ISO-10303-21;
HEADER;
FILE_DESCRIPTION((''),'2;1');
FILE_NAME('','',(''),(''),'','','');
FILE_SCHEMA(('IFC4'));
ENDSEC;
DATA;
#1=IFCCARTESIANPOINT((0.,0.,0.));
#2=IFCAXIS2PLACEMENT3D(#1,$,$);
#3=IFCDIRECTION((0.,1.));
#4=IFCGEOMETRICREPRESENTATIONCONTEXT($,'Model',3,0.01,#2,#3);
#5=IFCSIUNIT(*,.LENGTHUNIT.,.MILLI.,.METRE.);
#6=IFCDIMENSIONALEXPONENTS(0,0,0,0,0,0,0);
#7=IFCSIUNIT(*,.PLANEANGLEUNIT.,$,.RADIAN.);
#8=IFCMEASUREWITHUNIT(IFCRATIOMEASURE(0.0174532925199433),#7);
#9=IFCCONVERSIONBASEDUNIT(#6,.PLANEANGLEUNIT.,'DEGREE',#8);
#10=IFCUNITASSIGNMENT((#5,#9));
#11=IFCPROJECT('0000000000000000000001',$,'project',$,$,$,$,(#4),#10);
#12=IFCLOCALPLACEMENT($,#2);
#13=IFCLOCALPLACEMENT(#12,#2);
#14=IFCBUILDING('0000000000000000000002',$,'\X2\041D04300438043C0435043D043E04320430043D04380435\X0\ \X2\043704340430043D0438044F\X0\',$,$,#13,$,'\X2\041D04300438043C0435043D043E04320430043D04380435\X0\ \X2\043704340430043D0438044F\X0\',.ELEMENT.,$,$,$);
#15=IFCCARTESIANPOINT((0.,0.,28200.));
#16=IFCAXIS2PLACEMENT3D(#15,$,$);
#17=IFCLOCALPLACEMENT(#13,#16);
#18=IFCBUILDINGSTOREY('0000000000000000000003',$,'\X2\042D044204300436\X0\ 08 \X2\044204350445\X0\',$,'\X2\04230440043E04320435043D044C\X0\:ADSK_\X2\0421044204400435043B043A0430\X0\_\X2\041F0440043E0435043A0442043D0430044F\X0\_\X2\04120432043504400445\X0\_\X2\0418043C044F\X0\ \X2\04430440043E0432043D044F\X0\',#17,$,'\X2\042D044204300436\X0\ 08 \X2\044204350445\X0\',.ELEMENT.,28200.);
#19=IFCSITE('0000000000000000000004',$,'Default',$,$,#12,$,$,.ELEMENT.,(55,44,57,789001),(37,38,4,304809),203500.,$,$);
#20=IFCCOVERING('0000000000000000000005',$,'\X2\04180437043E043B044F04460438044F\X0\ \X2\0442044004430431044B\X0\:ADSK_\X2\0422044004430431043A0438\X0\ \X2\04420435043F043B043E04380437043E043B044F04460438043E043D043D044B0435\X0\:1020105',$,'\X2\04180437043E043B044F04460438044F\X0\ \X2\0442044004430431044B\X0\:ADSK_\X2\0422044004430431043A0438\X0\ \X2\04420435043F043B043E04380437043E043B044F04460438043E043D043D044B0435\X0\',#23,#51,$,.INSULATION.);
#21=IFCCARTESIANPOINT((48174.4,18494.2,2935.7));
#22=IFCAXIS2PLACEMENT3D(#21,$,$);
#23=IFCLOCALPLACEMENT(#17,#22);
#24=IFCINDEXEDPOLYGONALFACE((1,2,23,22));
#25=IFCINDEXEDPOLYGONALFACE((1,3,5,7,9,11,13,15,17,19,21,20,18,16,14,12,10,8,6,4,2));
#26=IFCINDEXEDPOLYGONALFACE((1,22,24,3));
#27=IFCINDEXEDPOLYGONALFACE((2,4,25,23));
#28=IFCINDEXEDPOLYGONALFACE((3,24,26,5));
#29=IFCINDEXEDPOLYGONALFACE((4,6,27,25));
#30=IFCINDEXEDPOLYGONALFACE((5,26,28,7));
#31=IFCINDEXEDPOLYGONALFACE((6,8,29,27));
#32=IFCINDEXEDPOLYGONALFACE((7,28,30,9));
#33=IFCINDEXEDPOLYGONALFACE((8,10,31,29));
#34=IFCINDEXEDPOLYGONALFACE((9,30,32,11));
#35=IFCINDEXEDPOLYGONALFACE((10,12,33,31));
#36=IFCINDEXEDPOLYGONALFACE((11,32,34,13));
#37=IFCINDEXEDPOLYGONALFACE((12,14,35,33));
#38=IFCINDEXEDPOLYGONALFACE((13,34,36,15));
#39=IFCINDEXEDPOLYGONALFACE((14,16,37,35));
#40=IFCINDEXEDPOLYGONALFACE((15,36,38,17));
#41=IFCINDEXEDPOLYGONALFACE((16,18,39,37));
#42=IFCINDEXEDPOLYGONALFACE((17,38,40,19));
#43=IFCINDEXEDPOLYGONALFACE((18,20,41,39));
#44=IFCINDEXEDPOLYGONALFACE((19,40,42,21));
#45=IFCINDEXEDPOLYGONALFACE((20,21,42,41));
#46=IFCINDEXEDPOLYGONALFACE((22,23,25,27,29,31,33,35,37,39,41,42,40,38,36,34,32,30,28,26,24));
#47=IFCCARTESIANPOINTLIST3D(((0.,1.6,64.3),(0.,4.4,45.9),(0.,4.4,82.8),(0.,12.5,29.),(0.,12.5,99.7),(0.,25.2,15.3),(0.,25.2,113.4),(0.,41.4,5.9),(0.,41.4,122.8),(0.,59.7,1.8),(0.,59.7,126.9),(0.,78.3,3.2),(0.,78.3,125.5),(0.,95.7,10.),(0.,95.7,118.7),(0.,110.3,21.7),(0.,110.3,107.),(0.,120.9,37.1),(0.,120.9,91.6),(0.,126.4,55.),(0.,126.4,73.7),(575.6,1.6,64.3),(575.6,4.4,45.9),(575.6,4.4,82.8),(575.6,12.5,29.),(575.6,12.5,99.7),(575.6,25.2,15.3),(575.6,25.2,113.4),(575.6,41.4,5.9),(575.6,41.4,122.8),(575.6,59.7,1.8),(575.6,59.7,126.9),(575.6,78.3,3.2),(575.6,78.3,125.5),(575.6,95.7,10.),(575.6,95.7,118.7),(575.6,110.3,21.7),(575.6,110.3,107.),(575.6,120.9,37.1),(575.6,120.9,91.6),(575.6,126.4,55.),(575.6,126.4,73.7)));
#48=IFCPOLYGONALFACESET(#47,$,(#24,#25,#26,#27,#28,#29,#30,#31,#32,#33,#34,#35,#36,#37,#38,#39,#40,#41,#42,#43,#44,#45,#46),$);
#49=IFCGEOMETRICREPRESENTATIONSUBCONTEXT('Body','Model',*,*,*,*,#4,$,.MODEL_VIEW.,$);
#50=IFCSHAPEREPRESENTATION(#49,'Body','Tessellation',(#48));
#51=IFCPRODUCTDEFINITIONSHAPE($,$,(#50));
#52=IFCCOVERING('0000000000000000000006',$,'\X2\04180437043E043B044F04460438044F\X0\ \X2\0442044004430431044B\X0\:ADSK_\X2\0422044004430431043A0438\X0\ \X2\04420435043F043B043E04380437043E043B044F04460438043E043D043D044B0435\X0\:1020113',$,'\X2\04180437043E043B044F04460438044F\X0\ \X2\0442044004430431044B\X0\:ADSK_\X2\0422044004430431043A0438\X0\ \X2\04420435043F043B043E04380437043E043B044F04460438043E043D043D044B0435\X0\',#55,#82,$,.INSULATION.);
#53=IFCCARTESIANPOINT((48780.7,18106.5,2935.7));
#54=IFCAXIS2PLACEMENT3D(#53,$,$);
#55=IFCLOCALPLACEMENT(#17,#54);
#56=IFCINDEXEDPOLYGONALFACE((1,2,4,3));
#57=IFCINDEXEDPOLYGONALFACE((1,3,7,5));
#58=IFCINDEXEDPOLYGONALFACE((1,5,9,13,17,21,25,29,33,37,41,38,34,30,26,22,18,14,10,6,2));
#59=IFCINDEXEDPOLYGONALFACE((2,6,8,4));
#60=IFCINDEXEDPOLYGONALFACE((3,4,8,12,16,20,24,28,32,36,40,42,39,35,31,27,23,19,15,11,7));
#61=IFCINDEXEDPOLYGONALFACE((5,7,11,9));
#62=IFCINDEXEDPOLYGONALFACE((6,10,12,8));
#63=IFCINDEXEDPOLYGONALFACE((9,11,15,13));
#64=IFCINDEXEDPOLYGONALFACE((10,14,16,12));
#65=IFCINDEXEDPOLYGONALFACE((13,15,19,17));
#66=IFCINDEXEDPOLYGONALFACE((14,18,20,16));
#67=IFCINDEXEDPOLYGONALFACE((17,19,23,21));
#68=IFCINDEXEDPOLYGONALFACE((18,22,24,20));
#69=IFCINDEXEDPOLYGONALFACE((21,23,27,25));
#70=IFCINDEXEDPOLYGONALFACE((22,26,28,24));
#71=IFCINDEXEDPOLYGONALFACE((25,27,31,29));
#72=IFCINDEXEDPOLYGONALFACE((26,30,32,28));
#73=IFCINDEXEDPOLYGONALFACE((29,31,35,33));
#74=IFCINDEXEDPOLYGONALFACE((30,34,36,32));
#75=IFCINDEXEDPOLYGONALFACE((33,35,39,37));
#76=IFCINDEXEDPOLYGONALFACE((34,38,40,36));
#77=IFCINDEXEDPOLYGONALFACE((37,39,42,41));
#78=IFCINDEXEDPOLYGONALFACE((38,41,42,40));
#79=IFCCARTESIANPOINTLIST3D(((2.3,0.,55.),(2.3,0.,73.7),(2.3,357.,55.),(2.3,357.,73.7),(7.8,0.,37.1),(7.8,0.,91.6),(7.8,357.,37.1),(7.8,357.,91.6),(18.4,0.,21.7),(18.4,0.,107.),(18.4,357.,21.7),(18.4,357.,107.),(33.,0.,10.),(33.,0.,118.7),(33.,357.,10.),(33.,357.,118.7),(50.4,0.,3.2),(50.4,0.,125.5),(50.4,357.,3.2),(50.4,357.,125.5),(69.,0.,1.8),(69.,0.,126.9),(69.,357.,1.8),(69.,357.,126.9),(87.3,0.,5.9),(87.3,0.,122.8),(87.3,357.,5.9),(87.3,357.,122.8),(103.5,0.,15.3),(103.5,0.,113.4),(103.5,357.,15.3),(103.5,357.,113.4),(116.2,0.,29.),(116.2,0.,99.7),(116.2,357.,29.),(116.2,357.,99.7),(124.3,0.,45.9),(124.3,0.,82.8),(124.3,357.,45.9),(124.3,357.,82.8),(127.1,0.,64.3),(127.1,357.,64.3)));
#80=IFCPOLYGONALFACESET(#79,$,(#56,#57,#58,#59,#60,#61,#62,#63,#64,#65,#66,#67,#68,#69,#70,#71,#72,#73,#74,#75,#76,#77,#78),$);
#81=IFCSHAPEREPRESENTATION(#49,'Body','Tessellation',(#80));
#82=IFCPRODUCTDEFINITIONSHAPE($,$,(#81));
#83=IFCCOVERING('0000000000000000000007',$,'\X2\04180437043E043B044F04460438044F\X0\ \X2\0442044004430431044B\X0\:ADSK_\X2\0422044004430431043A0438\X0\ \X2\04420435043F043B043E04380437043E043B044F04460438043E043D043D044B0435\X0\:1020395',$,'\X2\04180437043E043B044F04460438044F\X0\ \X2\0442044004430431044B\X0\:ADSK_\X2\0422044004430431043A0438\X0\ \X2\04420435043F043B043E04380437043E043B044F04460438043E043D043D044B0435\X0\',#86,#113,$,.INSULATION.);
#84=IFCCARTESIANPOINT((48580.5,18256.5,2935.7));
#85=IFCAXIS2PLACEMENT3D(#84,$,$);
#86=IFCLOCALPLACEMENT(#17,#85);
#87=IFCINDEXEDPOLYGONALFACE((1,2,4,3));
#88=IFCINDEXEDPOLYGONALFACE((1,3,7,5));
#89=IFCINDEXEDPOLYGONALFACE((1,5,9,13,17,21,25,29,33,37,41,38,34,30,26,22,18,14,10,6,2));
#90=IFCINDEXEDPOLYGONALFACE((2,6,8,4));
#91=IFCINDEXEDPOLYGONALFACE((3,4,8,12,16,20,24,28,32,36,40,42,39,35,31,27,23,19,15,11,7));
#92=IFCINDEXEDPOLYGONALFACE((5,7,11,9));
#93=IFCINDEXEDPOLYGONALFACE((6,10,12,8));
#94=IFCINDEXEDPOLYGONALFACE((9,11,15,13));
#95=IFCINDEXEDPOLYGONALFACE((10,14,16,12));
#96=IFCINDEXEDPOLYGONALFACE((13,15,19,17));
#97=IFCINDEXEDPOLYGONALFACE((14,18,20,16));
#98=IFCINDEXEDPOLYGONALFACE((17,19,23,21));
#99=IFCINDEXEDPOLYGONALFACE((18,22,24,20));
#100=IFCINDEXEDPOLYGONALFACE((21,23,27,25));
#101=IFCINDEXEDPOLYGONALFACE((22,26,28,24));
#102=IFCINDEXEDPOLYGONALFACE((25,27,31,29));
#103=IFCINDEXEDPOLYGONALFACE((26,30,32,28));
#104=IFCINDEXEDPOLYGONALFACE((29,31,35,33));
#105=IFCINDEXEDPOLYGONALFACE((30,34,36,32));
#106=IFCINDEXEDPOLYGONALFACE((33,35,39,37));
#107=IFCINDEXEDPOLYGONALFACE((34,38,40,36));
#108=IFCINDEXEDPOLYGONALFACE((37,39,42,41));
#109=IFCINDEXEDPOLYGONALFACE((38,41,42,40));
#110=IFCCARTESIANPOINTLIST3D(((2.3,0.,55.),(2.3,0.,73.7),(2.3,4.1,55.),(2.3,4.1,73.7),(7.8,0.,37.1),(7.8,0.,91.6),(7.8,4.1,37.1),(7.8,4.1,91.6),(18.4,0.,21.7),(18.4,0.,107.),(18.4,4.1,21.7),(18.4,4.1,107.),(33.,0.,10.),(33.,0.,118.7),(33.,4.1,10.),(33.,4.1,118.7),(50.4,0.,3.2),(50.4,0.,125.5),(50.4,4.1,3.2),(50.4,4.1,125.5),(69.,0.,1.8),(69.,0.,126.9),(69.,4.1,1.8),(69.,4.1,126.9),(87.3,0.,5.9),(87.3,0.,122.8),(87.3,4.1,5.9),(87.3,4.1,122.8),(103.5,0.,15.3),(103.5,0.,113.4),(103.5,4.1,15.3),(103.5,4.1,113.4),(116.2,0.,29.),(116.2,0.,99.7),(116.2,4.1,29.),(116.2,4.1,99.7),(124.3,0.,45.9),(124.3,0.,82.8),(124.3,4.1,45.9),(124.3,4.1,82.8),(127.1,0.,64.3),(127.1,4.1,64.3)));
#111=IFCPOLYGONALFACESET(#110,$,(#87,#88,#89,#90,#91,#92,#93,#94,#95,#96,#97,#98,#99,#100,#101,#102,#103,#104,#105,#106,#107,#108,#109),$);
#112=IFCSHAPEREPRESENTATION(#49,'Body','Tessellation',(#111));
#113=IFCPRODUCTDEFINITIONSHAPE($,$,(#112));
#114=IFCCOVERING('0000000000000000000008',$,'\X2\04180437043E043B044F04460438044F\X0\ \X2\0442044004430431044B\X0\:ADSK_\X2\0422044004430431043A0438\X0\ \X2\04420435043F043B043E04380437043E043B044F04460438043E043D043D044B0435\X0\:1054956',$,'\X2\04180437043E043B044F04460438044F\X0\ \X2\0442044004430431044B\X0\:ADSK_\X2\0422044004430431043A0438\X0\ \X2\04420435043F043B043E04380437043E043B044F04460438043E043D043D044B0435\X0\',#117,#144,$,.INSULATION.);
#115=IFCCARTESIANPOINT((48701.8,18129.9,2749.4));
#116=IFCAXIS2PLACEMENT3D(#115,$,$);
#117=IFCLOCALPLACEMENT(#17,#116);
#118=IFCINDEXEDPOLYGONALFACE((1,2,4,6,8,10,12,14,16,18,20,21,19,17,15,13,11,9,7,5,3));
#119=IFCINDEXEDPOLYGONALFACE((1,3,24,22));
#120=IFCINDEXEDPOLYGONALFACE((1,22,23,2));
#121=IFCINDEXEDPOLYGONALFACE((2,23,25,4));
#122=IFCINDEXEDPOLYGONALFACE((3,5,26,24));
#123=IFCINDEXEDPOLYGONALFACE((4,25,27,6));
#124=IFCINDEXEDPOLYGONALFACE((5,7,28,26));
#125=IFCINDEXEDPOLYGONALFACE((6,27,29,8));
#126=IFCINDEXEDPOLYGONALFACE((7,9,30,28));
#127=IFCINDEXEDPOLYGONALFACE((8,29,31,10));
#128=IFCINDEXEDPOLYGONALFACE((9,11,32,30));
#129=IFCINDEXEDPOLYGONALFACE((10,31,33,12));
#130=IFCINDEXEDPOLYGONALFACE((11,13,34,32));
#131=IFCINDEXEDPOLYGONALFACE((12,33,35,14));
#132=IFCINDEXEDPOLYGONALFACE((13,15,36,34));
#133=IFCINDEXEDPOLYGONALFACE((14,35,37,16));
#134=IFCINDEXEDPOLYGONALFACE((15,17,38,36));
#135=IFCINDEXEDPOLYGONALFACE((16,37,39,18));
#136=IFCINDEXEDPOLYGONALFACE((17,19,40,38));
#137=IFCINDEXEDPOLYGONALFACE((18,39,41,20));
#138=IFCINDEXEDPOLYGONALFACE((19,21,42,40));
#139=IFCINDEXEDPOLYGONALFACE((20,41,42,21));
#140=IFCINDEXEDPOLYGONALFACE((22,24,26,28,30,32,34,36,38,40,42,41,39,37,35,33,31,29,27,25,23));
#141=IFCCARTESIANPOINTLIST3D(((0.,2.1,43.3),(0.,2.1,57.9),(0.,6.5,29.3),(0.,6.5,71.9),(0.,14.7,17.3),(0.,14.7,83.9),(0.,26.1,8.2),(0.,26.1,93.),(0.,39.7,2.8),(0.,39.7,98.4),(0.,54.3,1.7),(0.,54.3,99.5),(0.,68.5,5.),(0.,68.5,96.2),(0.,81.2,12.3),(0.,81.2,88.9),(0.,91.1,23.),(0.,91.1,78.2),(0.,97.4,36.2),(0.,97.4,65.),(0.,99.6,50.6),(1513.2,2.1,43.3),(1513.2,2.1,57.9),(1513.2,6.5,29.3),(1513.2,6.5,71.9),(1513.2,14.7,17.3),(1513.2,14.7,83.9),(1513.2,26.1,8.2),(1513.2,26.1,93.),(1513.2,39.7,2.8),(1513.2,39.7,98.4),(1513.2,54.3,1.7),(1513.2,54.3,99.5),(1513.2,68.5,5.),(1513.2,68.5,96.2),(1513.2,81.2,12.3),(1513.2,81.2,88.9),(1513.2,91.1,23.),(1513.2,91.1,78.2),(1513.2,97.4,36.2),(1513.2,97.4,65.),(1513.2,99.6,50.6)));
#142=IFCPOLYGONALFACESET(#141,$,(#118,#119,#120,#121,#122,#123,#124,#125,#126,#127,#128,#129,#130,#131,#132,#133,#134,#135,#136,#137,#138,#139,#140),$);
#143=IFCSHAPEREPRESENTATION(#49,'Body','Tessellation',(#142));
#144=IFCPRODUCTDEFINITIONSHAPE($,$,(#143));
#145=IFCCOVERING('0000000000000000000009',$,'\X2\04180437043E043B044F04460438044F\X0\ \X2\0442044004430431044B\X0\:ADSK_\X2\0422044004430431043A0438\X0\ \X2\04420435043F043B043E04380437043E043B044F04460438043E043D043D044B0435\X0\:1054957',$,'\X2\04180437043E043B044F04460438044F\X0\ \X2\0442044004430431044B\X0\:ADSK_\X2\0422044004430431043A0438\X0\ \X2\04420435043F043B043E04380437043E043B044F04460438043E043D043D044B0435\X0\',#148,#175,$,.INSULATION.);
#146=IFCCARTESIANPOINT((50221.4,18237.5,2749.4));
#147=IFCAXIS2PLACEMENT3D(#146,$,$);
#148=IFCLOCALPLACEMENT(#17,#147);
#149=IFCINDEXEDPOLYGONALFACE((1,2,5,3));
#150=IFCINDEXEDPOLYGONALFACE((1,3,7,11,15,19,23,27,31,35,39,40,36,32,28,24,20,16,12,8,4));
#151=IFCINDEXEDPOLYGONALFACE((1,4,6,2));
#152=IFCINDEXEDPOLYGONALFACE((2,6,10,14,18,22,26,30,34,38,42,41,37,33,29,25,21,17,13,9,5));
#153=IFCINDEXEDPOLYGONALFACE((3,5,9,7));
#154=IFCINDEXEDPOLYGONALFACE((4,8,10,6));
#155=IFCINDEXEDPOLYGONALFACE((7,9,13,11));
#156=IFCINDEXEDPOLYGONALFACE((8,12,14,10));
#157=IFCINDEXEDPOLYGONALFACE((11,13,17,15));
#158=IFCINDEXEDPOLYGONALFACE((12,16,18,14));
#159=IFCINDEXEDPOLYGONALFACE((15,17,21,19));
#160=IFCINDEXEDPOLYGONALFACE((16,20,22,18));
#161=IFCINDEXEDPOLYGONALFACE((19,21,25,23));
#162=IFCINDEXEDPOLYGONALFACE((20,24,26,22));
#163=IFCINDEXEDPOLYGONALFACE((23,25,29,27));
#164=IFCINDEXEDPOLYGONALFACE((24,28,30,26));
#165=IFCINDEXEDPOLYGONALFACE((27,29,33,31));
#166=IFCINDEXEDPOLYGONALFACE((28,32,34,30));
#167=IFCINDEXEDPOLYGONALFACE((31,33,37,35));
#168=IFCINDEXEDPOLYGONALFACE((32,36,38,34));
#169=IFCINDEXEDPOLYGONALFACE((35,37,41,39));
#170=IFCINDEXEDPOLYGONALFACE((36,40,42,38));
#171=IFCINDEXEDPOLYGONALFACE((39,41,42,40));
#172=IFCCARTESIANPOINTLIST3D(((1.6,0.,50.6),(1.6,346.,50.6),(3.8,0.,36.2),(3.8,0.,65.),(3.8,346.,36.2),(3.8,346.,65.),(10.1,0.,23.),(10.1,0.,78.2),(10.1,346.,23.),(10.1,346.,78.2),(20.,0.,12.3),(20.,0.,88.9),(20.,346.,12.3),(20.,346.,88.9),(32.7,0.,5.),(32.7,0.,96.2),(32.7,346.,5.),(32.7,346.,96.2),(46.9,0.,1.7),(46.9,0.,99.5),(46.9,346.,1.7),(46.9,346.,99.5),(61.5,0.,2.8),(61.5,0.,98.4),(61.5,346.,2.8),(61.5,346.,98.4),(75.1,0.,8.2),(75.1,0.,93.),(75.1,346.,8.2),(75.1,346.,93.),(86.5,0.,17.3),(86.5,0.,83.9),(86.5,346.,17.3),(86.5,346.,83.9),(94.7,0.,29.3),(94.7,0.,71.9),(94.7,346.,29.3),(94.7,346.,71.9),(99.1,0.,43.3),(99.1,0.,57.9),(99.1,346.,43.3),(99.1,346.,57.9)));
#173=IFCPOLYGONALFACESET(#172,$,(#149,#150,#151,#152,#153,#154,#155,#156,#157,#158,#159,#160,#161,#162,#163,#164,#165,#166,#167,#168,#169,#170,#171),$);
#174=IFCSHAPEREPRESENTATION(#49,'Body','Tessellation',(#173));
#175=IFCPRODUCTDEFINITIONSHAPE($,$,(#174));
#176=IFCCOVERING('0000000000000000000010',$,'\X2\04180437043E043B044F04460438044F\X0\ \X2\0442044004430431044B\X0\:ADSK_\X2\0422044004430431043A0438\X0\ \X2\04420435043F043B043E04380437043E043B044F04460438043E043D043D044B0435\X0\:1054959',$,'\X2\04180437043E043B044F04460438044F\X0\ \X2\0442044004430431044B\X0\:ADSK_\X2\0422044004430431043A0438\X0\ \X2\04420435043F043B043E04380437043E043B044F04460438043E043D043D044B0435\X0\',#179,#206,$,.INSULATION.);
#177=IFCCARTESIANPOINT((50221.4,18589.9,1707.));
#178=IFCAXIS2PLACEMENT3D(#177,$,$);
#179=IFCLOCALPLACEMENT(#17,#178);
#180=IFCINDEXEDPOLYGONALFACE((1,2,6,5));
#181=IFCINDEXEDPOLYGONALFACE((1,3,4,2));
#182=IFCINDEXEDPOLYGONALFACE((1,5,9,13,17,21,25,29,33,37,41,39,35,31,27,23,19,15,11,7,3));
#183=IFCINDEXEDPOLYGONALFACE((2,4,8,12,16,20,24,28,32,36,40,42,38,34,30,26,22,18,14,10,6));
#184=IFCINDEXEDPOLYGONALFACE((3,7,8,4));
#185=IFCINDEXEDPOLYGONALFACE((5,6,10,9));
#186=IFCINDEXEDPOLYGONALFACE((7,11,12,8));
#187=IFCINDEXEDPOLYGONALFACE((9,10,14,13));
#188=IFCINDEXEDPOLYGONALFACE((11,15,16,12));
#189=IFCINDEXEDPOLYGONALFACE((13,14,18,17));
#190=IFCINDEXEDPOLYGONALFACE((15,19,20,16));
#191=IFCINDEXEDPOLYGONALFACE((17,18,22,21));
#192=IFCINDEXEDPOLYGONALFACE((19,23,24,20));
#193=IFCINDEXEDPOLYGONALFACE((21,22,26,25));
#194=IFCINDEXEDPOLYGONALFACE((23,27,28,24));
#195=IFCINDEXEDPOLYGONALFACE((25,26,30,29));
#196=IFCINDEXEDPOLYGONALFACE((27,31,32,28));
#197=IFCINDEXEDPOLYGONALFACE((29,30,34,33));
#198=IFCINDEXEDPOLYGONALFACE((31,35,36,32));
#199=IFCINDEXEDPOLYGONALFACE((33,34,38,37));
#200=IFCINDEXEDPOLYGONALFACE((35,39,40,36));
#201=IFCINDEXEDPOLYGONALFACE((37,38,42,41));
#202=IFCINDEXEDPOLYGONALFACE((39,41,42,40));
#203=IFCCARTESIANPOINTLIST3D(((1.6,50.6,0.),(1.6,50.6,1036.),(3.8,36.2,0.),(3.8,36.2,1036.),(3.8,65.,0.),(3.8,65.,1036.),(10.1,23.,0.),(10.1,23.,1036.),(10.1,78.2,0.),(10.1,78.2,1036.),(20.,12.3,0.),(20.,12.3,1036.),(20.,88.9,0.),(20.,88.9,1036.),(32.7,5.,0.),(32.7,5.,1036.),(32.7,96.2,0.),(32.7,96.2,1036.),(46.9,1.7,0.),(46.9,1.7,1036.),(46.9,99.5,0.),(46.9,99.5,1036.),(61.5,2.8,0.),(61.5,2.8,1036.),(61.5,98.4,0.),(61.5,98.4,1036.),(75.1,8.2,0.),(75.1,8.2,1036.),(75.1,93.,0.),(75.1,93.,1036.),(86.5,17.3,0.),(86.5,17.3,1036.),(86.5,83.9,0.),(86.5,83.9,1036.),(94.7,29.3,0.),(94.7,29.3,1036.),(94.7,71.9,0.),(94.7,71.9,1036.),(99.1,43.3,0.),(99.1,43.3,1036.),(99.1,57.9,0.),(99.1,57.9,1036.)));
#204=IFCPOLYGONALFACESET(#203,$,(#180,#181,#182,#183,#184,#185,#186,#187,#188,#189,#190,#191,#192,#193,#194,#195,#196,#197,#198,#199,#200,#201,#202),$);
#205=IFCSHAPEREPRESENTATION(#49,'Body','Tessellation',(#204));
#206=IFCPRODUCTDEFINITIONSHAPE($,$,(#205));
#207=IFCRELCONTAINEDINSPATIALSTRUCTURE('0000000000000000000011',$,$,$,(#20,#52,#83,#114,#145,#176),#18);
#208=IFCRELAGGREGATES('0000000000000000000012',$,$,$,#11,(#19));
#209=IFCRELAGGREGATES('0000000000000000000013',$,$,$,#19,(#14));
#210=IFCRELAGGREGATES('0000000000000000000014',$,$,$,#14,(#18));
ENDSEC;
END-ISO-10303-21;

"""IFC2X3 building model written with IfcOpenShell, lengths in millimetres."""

from ifc_helpers import new_model, entity, si_unit, converted_unit, direction, frame, origin, origin_2d_with_axis, place, context, subcontext, project, spatial, circle, extrude, element, save


model = new_model("IFC2X3")

# Units and contexts
model_context = context("Model", 3, precision=0.01, world=origin(), true_north=direction((0.0, 1.0)))
body_context = subcontext(model_context, "Body", "Model", "MODEL_VIEW")
ifc_project = project(units=[si_unit("LENGTHUNIT", "METRE", prefix="MILLI"), converted_unit("PLANEANGLEUNIT", "DEGREE", entity("IfcRatioMeasure", 0.0174532925199433), si_unit("PLANEANGLEUNIT", "RADIAN"), dimensions=[0, 0, 0, 0, 0, 0, 0])], contexts=[model_context])

# Site, building, storey
site_placement = place(None, origin())
site = spatial("IfcSite", under=ifc_project, at=site_placement, Name="Default", CompositionType="ELEMENT", RefLatitude=(55, 44, 57, 789001), RefLongitude=(37, 38, 4, 304809), RefElevation=203500.0)
building_placement = place(site_placement, origin())
building = spatial("IfcBuilding", under=site, at=building_placement, Name="Наименование здания", LongName="Наименование здания", CompositionType="ELEMENT")
storey_placement = place(building_placement, frame((0.0, 0.0, 28200.0)))
storey = spatial("IfcBuildingStorey", under=building, at=storey_placement, Name="Этаж 08 тех", ObjectType="Уровень:ADSK_Стрелка_Проектная_Вверх_Имя уровня", LongName="Этаж 08 тех", CompositionType="ELEMENT", Elevation=28200.0)

# Coverings
covering_1_placement = place(storey_placement, frame((48174.4, 18494.2, 2935.7)))
element("IfcCovering", 1, at=covering_1_placement, inside=storey, Name="Изоляция трубы:ADSK_Трубки теплоизоляционные:1020105", ObjectType="Изоляция трубы:ADSK_Трубки теплоизоляционные", PredefinedType="INSULATION", context=body_context, shape_type="SweptSolid", body=[
    extrude(circle(Radius=62.8, at=origin_2d_with_axis()), frame((0.0, 64.3, 64.3), z_axis=(1.0, 0.0, 0.0), x_axis=(0.0, -1.0, 0.0)), (0.0, 0.0, 1.0), 575.6),
])
covering_2_placement = place(storey_placement, frame((48780.7, 18106.5, 2935.7)))
element("IfcCovering", 2, at=covering_2_placement, inside=storey, Name="Изоляция трубы:ADSK_Трубки теплоизоляционные:1020113", ObjectType="Изоляция трубы:ADSK_Трубки теплоизоляционные", PredefinedType="INSULATION", context=body_context, shape_type="SweptSolid", body=[
    extrude(circle(Radius=62.8, at=origin_2d_with_axis()), frame((64.3, 0.0, 64.3), z_axis=(0.0, 1.0, 0.0), x_axis=(1.0, 0.0, 0.0)), (0.0, 0.0, 1.0), 357.0),
])
covering_3_placement = place(storey_placement, frame((48580.5, 18256.5, 2935.7)))
element("IfcCovering", 3, at=covering_3_placement, inside=storey, Name="Изоляция трубы:ADSK_Трубки теплоизоляционные:1020395", ObjectType="Изоляция трубы:ADSK_Трубки теплоизоляционные", PredefinedType="INSULATION", context=body_context, shape_type="SweptSolid", body=[
    extrude(circle(Radius=62.8, at=origin_2d_with_axis()), frame((64.3, 0.0, 64.3), z_axis=(0.0, 1.0, 0.0), x_axis=(1.0, 0.0, 0.0)), (0.0, 0.0, 1.0), 4.1),
])
covering_4_placement = place(storey_placement, frame((48701.8, 18129.9, 2749.4)))
element("IfcCovering", 4, at=covering_4_placement, inside=storey, Name="Изоляция трубы:ADSK_Трубки теплоизоляционные:1054956", ObjectType="Изоляция трубы:ADSK_Трубки теплоизоляционные", PredefinedType="INSULATION", context=body_context, shape_type="SweptSolid", body=[
    extrude(circle(Radius=49.0, at=origin_2d_with_axis()), frame((0.0, 50.6, 50.6), z_axis=(1.0, 0.0, 0.0), x_axis=(0.0, 1.0, 0.0)), (0.0, 0.0, 1.0), 1513.2),
])
covering_5_placement = place(storey_placement, frame((50221.4, 18237.5, 2749.4)))
element("IfcCovering", 5, at=covering_5_placement, inside=storey, Name="Изоляция трубы:ADSK_Трубки теплоизоляционные:1054957", ObjectType="Изоляция трубы:ADSK_Трубки теплоизоляционные", PredefinedType="INSULATION", context=body_context, shape_type="SweptSolid", body=[
    extrude(circle(Radius=49.0, at=origin_2d_with_axis()), frame((50.6, 0.0, 50.6), z_axis=(0.0, 1.0, 0.0), x_axis=(-1.0, 0.0, 0.0)), (0.0, 0.0, 1.0), 346.0),
])
covering_6_placement = place(storey_placement, frame((50221.4, 18589.9, 1707.0)))
element("IfcCovering", 6, at=covering_6_placement, inside=storey, Name="Изоляция трубы:ADSK_Трубки теплоизоляционные:1054959", ObjectType="Изоляция трубы:ADSK_Трубки теплоизоляционные", PredefinedType="INSULATION", context=body_context, shape_type="SweptSolid", body=[
    extrude(circle(Radius=49.0, at=origin_2d_with_axis()), frame((50.6, 50.6, 0.0), z_axis=(0.0, 0.0, 1.0), x_axis=(-1.0, 0.0, 0.0)), (0.0, 0.0, 1.0), 1036.0),
])

save(model, "model.ifc")
